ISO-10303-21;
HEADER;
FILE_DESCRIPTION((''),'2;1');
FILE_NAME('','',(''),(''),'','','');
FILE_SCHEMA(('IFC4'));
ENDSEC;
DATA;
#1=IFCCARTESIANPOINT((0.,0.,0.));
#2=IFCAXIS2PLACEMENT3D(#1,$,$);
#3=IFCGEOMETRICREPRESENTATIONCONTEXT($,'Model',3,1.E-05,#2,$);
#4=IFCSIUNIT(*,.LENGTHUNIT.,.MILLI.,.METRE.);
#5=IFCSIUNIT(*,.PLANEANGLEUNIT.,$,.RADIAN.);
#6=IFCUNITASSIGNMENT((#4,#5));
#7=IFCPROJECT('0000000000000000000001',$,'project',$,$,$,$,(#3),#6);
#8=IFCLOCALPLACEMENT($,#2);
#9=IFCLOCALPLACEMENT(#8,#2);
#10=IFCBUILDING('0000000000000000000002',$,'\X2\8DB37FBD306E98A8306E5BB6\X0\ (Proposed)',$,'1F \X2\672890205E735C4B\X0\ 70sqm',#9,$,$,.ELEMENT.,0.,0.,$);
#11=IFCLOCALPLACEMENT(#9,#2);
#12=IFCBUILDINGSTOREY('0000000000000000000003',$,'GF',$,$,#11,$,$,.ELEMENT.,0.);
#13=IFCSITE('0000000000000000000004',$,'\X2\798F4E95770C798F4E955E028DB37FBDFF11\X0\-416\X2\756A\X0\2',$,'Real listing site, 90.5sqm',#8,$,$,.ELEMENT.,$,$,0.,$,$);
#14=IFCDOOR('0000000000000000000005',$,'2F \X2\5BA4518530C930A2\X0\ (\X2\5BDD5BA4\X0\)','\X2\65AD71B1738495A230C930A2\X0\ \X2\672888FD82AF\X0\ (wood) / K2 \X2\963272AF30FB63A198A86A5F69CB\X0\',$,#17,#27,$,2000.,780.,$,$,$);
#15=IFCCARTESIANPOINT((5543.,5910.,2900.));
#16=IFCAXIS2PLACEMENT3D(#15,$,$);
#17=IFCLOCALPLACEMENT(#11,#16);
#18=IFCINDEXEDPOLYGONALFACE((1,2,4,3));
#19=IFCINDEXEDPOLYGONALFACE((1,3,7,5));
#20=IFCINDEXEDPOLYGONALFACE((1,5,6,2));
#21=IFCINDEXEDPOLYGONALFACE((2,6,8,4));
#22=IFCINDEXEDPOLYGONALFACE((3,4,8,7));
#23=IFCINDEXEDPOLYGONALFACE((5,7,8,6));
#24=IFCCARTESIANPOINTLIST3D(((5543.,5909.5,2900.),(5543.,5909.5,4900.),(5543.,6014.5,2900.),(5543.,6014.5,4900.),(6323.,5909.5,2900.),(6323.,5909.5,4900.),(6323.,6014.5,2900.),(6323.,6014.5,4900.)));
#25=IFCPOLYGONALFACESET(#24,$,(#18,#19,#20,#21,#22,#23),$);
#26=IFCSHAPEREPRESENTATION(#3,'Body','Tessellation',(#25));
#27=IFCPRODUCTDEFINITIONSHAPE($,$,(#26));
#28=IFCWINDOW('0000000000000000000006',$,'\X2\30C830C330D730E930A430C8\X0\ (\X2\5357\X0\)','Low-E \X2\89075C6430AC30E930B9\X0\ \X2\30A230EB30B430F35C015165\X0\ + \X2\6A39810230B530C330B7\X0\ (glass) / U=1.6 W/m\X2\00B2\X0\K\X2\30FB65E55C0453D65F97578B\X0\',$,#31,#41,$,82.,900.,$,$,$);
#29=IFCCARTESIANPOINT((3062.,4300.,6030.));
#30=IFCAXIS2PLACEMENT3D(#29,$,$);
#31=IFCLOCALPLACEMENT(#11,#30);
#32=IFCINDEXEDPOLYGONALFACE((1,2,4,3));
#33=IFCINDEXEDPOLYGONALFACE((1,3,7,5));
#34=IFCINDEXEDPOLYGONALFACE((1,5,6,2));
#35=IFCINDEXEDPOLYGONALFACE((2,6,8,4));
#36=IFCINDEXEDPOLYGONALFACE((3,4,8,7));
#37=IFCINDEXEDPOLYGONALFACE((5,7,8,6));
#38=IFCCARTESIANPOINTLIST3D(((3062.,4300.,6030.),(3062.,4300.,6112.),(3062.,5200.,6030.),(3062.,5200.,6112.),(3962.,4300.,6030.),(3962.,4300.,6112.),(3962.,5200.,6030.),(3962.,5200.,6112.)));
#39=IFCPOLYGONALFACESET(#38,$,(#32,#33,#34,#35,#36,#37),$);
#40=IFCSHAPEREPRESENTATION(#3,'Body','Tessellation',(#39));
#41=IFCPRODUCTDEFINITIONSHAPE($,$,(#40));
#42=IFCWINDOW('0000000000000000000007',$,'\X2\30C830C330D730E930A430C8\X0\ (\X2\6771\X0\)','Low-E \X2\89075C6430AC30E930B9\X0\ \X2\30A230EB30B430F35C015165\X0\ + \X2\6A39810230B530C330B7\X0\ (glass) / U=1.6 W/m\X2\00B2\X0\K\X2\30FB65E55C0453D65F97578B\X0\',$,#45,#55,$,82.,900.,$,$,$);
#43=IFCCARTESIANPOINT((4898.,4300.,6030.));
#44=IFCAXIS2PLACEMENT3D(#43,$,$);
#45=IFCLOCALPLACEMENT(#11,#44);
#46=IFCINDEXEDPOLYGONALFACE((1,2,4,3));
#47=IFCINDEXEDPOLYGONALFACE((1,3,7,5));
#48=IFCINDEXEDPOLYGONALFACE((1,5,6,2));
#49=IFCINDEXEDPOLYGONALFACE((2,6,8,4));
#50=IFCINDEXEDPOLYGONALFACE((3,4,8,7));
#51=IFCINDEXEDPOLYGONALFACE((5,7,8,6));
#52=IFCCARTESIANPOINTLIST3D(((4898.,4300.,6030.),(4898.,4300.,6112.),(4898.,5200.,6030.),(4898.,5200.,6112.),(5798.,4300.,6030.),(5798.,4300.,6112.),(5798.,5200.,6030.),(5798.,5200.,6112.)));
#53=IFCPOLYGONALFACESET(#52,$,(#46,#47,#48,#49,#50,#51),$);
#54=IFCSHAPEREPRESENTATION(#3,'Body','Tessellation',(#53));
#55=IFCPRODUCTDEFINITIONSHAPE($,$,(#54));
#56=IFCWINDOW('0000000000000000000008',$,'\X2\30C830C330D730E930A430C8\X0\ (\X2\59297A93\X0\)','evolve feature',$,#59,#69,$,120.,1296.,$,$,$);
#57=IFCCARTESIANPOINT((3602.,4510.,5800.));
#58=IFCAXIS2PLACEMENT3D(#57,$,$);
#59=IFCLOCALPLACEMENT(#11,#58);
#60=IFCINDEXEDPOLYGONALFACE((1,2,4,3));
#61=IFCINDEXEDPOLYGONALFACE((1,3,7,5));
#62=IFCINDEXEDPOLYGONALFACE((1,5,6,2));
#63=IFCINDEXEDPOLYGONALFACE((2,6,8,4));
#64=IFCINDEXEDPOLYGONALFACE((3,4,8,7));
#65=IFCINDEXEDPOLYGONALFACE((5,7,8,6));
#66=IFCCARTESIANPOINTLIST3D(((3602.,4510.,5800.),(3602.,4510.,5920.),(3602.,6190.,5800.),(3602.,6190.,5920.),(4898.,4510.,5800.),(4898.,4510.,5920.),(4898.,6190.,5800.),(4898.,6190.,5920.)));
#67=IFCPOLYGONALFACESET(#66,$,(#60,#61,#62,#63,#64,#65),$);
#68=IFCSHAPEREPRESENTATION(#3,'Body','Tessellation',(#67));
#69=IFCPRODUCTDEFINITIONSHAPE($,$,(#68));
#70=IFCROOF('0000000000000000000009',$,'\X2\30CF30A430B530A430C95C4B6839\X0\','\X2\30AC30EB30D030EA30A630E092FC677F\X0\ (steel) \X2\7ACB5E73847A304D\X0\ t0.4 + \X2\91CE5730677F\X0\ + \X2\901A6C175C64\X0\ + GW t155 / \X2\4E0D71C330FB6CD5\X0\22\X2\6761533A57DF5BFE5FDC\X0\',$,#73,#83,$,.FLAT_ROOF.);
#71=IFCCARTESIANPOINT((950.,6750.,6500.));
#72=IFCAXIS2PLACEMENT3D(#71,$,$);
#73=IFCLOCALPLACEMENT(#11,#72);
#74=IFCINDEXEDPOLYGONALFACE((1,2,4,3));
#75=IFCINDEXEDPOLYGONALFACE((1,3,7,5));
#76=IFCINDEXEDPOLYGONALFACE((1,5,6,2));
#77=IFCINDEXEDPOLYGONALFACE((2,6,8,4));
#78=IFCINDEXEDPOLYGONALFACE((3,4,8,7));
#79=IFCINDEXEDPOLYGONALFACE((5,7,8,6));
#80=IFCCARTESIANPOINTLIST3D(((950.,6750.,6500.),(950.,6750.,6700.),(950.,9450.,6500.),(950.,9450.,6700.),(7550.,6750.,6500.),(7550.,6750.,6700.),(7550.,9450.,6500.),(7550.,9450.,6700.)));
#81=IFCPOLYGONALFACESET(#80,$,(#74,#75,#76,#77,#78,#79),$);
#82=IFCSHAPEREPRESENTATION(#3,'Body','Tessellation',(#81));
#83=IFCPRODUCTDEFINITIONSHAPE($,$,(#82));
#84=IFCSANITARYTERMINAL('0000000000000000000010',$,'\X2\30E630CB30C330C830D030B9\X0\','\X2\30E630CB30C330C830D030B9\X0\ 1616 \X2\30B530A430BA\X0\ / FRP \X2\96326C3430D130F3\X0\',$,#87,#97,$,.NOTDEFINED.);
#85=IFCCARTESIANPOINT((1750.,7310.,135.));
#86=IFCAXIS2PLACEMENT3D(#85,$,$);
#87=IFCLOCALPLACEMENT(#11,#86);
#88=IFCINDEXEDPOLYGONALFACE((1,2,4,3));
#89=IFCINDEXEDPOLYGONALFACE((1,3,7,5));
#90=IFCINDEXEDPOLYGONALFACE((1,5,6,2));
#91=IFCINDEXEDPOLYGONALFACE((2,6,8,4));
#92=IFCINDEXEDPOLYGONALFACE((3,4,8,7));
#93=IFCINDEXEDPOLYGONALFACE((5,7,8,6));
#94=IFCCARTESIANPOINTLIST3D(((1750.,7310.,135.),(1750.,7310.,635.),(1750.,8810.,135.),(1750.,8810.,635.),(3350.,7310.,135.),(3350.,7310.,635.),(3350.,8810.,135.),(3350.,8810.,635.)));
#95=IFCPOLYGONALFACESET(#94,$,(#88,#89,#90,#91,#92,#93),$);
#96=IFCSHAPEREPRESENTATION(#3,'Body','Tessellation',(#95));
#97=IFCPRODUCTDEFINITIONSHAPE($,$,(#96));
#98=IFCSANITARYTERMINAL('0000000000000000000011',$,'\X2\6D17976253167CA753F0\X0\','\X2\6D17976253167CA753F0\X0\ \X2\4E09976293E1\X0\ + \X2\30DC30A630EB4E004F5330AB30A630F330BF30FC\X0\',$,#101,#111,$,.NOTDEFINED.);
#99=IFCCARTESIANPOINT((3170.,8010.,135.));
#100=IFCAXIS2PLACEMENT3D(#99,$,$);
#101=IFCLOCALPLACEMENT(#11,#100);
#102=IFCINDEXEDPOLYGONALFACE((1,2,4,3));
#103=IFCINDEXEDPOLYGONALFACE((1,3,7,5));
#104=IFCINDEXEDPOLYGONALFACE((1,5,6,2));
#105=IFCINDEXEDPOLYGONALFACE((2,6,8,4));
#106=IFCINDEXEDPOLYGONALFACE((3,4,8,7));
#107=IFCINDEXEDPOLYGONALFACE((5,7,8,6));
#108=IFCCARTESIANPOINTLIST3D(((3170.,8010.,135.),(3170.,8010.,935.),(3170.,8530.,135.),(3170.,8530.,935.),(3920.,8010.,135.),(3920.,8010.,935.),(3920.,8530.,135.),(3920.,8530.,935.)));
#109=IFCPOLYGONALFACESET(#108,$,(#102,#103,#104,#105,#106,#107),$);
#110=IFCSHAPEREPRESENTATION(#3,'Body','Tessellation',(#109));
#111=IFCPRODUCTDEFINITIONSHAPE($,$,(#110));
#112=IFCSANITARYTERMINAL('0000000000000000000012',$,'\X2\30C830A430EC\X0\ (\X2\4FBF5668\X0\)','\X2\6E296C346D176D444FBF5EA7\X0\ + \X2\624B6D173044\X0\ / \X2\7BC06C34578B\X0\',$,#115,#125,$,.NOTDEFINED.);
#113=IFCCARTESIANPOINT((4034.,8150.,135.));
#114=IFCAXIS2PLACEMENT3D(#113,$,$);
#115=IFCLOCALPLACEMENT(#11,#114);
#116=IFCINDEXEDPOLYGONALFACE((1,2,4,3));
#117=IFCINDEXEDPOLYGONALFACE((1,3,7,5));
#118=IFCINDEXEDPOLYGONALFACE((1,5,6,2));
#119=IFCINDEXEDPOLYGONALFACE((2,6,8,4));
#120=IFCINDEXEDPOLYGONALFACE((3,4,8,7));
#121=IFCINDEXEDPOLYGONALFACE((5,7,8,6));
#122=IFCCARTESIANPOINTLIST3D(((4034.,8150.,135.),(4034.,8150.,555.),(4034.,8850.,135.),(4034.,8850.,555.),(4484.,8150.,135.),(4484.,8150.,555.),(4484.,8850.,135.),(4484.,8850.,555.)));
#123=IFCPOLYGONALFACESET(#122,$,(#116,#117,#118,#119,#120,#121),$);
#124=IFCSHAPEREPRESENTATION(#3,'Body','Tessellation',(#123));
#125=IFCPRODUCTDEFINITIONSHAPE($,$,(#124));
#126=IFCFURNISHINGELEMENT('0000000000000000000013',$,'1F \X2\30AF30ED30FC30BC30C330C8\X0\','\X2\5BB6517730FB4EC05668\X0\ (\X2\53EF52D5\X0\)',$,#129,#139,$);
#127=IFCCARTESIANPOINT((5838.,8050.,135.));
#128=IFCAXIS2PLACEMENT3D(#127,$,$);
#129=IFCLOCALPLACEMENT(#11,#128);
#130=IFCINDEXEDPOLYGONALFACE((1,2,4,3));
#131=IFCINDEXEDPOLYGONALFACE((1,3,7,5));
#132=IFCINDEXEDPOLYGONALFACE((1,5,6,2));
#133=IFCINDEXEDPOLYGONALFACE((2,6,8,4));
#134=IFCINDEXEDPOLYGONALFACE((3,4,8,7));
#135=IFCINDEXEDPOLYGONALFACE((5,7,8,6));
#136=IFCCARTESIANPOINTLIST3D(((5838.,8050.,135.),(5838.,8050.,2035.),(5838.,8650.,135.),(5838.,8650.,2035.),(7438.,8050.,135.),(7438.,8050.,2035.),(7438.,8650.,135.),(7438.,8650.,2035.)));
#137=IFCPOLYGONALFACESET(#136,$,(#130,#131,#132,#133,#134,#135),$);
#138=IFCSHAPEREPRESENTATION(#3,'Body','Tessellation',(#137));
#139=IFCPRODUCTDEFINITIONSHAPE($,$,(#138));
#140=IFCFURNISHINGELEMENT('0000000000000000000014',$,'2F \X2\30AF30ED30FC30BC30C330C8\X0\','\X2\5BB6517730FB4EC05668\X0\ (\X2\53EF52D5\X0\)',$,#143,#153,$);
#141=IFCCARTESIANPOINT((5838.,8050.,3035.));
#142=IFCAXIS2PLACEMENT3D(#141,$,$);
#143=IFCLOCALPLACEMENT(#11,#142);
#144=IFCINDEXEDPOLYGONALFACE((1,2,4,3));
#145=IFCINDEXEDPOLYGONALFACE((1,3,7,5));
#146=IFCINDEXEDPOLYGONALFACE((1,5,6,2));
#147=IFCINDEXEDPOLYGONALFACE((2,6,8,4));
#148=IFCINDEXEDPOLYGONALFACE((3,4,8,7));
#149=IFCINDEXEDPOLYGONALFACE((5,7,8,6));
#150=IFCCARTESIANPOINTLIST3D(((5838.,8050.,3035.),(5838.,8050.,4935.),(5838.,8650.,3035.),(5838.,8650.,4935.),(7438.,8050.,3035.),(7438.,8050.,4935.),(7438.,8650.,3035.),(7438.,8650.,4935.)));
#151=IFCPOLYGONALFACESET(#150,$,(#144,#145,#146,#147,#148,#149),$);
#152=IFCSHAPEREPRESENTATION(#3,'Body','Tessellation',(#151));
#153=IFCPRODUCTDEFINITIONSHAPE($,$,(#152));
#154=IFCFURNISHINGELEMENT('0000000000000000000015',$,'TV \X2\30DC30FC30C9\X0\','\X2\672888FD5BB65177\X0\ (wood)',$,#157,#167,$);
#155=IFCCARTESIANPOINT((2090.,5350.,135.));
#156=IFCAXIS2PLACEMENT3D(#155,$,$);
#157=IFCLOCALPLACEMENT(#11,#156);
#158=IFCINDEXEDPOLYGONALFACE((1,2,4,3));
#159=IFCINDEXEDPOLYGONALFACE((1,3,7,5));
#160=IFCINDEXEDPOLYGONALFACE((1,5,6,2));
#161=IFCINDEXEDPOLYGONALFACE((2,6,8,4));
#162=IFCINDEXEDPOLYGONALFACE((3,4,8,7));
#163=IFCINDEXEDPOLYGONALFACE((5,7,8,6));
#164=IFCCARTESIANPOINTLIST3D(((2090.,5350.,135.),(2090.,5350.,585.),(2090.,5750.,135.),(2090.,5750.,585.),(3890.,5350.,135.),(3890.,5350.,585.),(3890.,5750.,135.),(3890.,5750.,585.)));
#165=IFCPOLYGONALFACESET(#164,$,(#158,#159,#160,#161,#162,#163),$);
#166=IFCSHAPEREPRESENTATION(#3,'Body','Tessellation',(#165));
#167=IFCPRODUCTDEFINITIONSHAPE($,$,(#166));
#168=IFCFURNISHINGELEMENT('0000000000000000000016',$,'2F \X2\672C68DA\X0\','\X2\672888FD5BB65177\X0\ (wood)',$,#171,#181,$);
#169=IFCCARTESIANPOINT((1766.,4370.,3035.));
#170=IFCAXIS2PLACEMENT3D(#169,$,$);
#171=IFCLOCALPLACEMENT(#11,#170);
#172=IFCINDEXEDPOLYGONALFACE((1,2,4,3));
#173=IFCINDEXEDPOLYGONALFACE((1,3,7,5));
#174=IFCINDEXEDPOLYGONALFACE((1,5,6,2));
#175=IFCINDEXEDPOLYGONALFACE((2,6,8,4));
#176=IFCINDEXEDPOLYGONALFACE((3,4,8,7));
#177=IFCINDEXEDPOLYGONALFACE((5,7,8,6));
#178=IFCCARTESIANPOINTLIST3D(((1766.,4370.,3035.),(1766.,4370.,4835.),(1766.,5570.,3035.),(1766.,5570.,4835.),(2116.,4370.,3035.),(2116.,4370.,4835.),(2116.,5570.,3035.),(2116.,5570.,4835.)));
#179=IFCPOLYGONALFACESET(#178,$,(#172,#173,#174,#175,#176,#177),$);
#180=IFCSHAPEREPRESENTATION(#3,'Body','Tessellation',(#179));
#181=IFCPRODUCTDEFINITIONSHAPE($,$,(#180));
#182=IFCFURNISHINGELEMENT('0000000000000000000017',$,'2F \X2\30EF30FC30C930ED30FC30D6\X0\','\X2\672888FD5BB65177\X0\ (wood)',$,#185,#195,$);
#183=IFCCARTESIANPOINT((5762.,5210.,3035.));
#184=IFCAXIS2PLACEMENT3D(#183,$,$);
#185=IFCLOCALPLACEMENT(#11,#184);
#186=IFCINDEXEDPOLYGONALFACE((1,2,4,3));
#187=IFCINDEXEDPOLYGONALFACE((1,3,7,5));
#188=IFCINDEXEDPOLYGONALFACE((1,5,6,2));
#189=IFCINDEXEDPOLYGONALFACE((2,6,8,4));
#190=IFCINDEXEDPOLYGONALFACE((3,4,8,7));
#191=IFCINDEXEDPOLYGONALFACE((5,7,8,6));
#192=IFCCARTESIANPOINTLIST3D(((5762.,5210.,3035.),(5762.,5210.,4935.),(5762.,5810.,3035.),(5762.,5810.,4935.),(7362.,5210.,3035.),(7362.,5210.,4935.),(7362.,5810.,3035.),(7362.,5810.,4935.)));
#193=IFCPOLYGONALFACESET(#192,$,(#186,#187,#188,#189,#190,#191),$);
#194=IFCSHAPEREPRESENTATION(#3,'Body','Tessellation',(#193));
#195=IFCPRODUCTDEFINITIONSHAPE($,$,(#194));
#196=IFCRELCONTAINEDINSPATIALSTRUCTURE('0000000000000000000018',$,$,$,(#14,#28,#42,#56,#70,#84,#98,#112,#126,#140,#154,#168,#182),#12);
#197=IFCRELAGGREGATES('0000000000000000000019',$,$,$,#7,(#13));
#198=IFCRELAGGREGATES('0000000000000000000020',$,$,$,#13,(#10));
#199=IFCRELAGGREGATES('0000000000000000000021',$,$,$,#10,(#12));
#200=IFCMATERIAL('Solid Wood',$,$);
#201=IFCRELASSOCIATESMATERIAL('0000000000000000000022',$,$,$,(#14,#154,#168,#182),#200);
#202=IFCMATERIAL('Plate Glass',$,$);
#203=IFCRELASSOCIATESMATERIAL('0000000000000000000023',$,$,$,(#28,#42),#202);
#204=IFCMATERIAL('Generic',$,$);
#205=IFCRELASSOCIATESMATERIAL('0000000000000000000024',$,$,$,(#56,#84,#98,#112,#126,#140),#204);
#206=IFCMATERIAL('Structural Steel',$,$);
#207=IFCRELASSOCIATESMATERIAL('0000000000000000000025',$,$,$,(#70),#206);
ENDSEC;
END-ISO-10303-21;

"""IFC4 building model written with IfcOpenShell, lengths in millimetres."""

from ifc_helpers import new_model, si_unit, frame, frame_2d, origin, place, context, project, spatial, rectangle, extrude, material, element, save


model = new_model("IFC4")

# Units and contexts
model_context = context("Model", 3, precision=1e-05, world=origin())
ifc_project = project(units=[si_unit("LENGTHUNIT", "METRE", prefix="MILLI"), si_unit("PLANEANGLEUNIT", "RADIAN")], contexts=[model_context])

# Site, building, storey
site_placement = place(None, origin())
site = spatial("IfcSite", under=ifc_project, at=site_placement, Name="福井県福井市足羽１-416番2", ObjectType="Real listing site, 90.5sqm", CompositionType="ELEMENT", RefElevation=0.0)
building_placement = place(site_placement, origin())
building = spatial("IfcBuilding", under=site, at=building_placement, Name="足羽の風の家 (Proposed)", ObjectType="1F 木造平屋 70sqm", CompositionType="ELEMENT", ElevationOfRefHeight=0.0, ElevationOfTerrain=0.0)
storey_placement = place(building_placement, origin())
storey = spatial("IfcBuildingStorey", under=building, at=storey_placement, Name="GF", CompositionType="ELEMENT", Elevation=0.0)

# Shared definitions
ifc_material_1 = material(Name="Solid Wood")
ifc_material_2 = material(Name="Plate Glass")

# Door
door_1_placement = place(storey_placement, frame((5543.0, 5910.0, 2900.0)))
element("IfcDoor", 1, at=door_1_placement, inside=storey, material=ifc_material_1, Name="2F 室内ドア (寝室)", Description="断熱玄関ドア 木製芯 (wood) / K2 防犯・採風機構", OverallHeight=2000.0, OverallWidth=780.0, context=model_context, shape_type="SweptSolid", body=[
    extrude(rectangle(XDim=780.0, YDim=105.0, at=frame_2d((390.0, 52.0))), frame((5543.0, 5910.0, 2900.0)), (0.0, 0.0, 1.0), 2000.0),
])

# Windows
window_1_placement = place(storey_placement, frame((3062.0, 4300.0, 6030.0)))
element("IfcWindow", 2, at=window_1_placement, inside=storey, material=ifc_material_2, Name="トップライト (南)", Description="Low-E 複層ガラス アルゴン封入 + 樹脂サッシ (glass) / U=1.6 W/m²K・日射取得型", OverallHeight=82.0, OverallWidth=900.0, context=model_context, shape_type="SweptSolid", body=[
    extrude(rectangle(XDim=900.0, YDim=900.0, at=frame_2d((450.0, 450.0))), frame((3062.0, 4300.0, 6030.0)), (0.0, 0.0, 1.0), 82.0),
])
window_2_placement = place(storey_placement, frame((4898.0, 4300.0, 6030.0)))
element("IfcWindow", 3, at=window_2_placement, inside=storey, material=ifc_material_2, Name="トップライト (東)", Description="Low-E 複層ガラス アルゴン封入 + 樹脂サッシ (glass) / U=1.6 W/m²K・日射取得型", OverallHeight=82.0, OverallWidth=900.0, context=model_context, shape_type="SweptSolid", body=[
    extrude(rectangle(XDim=900.0, YDim=900.0, at=frame_2d((450.0, 450.0))), frame((4898.0, 4300.0, 6030.0)), (0.0, 0.0, 1.0), 82.0),
])
ifc_material_3 = material(Name="Generic")
window_3_placement = place(storey_placement, frame((3602.0, 4510.0, 5800.0)))
element("IfcWindow", 4, at=window_3_placement, inside=storey, material=ifc_material_3, Name="トップライト (天窓)", Description="evolve feature", OverallHeight=120.0, OverallWidth=1296.0, context=model_context, shape_type="SweptSolid", body=[
    extrude(rectangle(XDim=1296.0, YDim=1680.0, at=frame_2d((648.0, 840.0))), frame((3602.0, 4510.0, 5800.0)), (0.0, 0.0, 1.0), 120.0),
])

# Roof
ifc_material_4 = material(Name="Structural Steel")
roof_placement = place(storey_placement, frame((950.0, 6750.0, 6500.0)))
element("IfcRoof", 5, at=roof_placement, inside=storey, material=ifc_material_4, Name="ハイサイド屋根", Description="ガルバリウム鋼板 (steel) 立平葺き t0.4 + 野地板 + 通気層 + GW t155 / 不燃・法22条区域対応", PredefinedType="FLAT_ROOF", context=model_context, shape_type="SweptSolid", body=[
    extrude(rectangle(XDim=6600.0, YDim=2700.0, at=frame_2d((3300.0, 1350.0))), frame((950.0, 6750.0, 6500.0)), (0.0, 0.0, 1.0), 200.0),
])

# Sanitary terminals
sanitary_terminal_1_placement = place(storey_placement, frame((1750.0, 7310.0, 135.0)))
element("IfcSanitaryTerminal", 6, at=sanitary_terminal_1_placement, inside=storey, material=ifc_material_3, Name="ユニットバス", Description="ユニットバス 1616 サイズ / FRP 防水パン", PredefinedType="NOTDEFINED", context=model_context, shape_type="SweptSolid", body=[
    extrude(rectangle(XDim=1600.0, YDim=1500.0, at=frame_2d((800.0, 750.0))), frame((1750.0, 7310.0, 135.0)), (0.0, 0.0, 1.0), 500.0),
])
sanitary_terminal_2_placement = place(storey_placement, frame((3170.0, 8010.0, 135.0)))
element("IfcSanitaryTerminal", 7, at=sanitary_terminal_2_placement, inside=storey, material=ifc_material_3, Name="洗面化粧台", Description="洗面化粧台 三面鏡 + ボウル一体カウンター", PredefinedType="NOTDEFINED", context=model_context, shape_type="SweptSolid", body=[
    extrude(rectangle(XDim=750.0, YDim=520.0, at=frame_2d((375.0, 260.0))), frame((3170.0, 8010.0, 135.0)), (0.0, 0.0, 1.0), 800.0),
])
sanitary_terminal_3_placement = place(storey_placement, frame((4034.0, 8150.0, 135.0)))
element("IfcSanitaryTerminal", 8, at=sanitary_terminal_3_placement, inside=storey, material=ifc_material_3, Name="トイレ (便器)", Description="温水洗浄便座 + 手洗い / 節水型", PredefinedType="NOTDEFINED", context=model_context, shape_type="SweptSolid", body=[
    extrude(rectangle(XDim=450.0, YDim=700.0, at=frame_2d((225.0, 350.0))), frame((4034.0, 8150.0, 135.0)), (0.0, 0.0, 1.0), 420.0),
])

# Furnishing elements
furnishing_1_placement = place(storey_placement, frame((5838.0, 8050.0, 135.0)))
element("IfcFurnishingElement", 9, at=furnishing_1_placement, inside=storey, material=ifc_material_3, Name="1F クローゼット", Description="家具・什器 (可動)", context=model_context, shape_type="SweptSolid", body=[
    extrude(rectangle(XDim=1600.0, YDim=600.0, at=frame_2d((800.0, 300.0))), frame((5838.0, 8050.0, 135.0)), (0.0, 0.0, 1.0), 1900.0),
])
furnishing_2_placement = place(storey_placement, frame((5838.0, 8050.0, 3035.0)))
element("IfcFurnishingElement", 10, at=furnishing_2_placement, inside=storey, material=ifc_material_3, Name="2F クローゼット", Description="家具・什器 (可動)", context=model_context, shape_type="SweptSolid", body=[
    extrude(rectangle(XDim=1600.0, YDim=600.0, at=frame_2d((800.0, 300.0))), frame((5838.0, 8050.0, 3035.0)), (0.0, 0.0, 1.0), 1900.0),
])
furnishing_3_placement = place(storey_placement, frame((2090.0, 5350.0, 135.0)))
element("IfcFurnishingElement", 11, at=furnishing_3_placement, inside=storey, material=ifc_material_1, Name="TV ボード", Description="木製家具 (wood)", context=model_context, shape_type="SweptSolid", body=[
    extrude(rectangle(XDim=1800.0, YDim=400.0, at=frame_2d((900.0, 200.0))), frame((2090.0, 5350.0, 135.0)), (0.0, 0.0, 1.0), 450.0),
])
furnishing_4_placement = place(storey_placement, frame((1766.0, 4370.0, 3035.0)))
element("IfcFurnishingElement", 12, at=furnishing_4_placement, inside=storey, material=ifc_material_1, Name="2F 本棚", Description="木製家具 (wood)", context=model_context, shape_type="SweptSolid", body=[
    extrude(rectangle(XDim=350.0, YDim=1200.0, at=frame_2d((175.0, 600.0))), frame((1766.0, 4370.0, 3035.0)), (0.0, 0.0, 1.0), 1800.0),
])
furnishing_5_placement = place(storey_placement, frame((5762.0, 5210.0, 3035.0)))
element("IfcFurnishingElement", 13, at=furnishing_5_placement, inside=storey, material=ifc_material_1, Name="2F ワードローブ", Description="木製家具 (wood)", context=model_context, shape_type="SweptSolid", body=[
    extrude(rectangle(XDim=1600.0, YDim=600.0, at=frame_2d((800.0, 300.0))), frame((5762.0, 5210.0, 3035.0)), (0.0, 0.0, 1.0), 1900.0),
])

save(model, "model.ifc")
